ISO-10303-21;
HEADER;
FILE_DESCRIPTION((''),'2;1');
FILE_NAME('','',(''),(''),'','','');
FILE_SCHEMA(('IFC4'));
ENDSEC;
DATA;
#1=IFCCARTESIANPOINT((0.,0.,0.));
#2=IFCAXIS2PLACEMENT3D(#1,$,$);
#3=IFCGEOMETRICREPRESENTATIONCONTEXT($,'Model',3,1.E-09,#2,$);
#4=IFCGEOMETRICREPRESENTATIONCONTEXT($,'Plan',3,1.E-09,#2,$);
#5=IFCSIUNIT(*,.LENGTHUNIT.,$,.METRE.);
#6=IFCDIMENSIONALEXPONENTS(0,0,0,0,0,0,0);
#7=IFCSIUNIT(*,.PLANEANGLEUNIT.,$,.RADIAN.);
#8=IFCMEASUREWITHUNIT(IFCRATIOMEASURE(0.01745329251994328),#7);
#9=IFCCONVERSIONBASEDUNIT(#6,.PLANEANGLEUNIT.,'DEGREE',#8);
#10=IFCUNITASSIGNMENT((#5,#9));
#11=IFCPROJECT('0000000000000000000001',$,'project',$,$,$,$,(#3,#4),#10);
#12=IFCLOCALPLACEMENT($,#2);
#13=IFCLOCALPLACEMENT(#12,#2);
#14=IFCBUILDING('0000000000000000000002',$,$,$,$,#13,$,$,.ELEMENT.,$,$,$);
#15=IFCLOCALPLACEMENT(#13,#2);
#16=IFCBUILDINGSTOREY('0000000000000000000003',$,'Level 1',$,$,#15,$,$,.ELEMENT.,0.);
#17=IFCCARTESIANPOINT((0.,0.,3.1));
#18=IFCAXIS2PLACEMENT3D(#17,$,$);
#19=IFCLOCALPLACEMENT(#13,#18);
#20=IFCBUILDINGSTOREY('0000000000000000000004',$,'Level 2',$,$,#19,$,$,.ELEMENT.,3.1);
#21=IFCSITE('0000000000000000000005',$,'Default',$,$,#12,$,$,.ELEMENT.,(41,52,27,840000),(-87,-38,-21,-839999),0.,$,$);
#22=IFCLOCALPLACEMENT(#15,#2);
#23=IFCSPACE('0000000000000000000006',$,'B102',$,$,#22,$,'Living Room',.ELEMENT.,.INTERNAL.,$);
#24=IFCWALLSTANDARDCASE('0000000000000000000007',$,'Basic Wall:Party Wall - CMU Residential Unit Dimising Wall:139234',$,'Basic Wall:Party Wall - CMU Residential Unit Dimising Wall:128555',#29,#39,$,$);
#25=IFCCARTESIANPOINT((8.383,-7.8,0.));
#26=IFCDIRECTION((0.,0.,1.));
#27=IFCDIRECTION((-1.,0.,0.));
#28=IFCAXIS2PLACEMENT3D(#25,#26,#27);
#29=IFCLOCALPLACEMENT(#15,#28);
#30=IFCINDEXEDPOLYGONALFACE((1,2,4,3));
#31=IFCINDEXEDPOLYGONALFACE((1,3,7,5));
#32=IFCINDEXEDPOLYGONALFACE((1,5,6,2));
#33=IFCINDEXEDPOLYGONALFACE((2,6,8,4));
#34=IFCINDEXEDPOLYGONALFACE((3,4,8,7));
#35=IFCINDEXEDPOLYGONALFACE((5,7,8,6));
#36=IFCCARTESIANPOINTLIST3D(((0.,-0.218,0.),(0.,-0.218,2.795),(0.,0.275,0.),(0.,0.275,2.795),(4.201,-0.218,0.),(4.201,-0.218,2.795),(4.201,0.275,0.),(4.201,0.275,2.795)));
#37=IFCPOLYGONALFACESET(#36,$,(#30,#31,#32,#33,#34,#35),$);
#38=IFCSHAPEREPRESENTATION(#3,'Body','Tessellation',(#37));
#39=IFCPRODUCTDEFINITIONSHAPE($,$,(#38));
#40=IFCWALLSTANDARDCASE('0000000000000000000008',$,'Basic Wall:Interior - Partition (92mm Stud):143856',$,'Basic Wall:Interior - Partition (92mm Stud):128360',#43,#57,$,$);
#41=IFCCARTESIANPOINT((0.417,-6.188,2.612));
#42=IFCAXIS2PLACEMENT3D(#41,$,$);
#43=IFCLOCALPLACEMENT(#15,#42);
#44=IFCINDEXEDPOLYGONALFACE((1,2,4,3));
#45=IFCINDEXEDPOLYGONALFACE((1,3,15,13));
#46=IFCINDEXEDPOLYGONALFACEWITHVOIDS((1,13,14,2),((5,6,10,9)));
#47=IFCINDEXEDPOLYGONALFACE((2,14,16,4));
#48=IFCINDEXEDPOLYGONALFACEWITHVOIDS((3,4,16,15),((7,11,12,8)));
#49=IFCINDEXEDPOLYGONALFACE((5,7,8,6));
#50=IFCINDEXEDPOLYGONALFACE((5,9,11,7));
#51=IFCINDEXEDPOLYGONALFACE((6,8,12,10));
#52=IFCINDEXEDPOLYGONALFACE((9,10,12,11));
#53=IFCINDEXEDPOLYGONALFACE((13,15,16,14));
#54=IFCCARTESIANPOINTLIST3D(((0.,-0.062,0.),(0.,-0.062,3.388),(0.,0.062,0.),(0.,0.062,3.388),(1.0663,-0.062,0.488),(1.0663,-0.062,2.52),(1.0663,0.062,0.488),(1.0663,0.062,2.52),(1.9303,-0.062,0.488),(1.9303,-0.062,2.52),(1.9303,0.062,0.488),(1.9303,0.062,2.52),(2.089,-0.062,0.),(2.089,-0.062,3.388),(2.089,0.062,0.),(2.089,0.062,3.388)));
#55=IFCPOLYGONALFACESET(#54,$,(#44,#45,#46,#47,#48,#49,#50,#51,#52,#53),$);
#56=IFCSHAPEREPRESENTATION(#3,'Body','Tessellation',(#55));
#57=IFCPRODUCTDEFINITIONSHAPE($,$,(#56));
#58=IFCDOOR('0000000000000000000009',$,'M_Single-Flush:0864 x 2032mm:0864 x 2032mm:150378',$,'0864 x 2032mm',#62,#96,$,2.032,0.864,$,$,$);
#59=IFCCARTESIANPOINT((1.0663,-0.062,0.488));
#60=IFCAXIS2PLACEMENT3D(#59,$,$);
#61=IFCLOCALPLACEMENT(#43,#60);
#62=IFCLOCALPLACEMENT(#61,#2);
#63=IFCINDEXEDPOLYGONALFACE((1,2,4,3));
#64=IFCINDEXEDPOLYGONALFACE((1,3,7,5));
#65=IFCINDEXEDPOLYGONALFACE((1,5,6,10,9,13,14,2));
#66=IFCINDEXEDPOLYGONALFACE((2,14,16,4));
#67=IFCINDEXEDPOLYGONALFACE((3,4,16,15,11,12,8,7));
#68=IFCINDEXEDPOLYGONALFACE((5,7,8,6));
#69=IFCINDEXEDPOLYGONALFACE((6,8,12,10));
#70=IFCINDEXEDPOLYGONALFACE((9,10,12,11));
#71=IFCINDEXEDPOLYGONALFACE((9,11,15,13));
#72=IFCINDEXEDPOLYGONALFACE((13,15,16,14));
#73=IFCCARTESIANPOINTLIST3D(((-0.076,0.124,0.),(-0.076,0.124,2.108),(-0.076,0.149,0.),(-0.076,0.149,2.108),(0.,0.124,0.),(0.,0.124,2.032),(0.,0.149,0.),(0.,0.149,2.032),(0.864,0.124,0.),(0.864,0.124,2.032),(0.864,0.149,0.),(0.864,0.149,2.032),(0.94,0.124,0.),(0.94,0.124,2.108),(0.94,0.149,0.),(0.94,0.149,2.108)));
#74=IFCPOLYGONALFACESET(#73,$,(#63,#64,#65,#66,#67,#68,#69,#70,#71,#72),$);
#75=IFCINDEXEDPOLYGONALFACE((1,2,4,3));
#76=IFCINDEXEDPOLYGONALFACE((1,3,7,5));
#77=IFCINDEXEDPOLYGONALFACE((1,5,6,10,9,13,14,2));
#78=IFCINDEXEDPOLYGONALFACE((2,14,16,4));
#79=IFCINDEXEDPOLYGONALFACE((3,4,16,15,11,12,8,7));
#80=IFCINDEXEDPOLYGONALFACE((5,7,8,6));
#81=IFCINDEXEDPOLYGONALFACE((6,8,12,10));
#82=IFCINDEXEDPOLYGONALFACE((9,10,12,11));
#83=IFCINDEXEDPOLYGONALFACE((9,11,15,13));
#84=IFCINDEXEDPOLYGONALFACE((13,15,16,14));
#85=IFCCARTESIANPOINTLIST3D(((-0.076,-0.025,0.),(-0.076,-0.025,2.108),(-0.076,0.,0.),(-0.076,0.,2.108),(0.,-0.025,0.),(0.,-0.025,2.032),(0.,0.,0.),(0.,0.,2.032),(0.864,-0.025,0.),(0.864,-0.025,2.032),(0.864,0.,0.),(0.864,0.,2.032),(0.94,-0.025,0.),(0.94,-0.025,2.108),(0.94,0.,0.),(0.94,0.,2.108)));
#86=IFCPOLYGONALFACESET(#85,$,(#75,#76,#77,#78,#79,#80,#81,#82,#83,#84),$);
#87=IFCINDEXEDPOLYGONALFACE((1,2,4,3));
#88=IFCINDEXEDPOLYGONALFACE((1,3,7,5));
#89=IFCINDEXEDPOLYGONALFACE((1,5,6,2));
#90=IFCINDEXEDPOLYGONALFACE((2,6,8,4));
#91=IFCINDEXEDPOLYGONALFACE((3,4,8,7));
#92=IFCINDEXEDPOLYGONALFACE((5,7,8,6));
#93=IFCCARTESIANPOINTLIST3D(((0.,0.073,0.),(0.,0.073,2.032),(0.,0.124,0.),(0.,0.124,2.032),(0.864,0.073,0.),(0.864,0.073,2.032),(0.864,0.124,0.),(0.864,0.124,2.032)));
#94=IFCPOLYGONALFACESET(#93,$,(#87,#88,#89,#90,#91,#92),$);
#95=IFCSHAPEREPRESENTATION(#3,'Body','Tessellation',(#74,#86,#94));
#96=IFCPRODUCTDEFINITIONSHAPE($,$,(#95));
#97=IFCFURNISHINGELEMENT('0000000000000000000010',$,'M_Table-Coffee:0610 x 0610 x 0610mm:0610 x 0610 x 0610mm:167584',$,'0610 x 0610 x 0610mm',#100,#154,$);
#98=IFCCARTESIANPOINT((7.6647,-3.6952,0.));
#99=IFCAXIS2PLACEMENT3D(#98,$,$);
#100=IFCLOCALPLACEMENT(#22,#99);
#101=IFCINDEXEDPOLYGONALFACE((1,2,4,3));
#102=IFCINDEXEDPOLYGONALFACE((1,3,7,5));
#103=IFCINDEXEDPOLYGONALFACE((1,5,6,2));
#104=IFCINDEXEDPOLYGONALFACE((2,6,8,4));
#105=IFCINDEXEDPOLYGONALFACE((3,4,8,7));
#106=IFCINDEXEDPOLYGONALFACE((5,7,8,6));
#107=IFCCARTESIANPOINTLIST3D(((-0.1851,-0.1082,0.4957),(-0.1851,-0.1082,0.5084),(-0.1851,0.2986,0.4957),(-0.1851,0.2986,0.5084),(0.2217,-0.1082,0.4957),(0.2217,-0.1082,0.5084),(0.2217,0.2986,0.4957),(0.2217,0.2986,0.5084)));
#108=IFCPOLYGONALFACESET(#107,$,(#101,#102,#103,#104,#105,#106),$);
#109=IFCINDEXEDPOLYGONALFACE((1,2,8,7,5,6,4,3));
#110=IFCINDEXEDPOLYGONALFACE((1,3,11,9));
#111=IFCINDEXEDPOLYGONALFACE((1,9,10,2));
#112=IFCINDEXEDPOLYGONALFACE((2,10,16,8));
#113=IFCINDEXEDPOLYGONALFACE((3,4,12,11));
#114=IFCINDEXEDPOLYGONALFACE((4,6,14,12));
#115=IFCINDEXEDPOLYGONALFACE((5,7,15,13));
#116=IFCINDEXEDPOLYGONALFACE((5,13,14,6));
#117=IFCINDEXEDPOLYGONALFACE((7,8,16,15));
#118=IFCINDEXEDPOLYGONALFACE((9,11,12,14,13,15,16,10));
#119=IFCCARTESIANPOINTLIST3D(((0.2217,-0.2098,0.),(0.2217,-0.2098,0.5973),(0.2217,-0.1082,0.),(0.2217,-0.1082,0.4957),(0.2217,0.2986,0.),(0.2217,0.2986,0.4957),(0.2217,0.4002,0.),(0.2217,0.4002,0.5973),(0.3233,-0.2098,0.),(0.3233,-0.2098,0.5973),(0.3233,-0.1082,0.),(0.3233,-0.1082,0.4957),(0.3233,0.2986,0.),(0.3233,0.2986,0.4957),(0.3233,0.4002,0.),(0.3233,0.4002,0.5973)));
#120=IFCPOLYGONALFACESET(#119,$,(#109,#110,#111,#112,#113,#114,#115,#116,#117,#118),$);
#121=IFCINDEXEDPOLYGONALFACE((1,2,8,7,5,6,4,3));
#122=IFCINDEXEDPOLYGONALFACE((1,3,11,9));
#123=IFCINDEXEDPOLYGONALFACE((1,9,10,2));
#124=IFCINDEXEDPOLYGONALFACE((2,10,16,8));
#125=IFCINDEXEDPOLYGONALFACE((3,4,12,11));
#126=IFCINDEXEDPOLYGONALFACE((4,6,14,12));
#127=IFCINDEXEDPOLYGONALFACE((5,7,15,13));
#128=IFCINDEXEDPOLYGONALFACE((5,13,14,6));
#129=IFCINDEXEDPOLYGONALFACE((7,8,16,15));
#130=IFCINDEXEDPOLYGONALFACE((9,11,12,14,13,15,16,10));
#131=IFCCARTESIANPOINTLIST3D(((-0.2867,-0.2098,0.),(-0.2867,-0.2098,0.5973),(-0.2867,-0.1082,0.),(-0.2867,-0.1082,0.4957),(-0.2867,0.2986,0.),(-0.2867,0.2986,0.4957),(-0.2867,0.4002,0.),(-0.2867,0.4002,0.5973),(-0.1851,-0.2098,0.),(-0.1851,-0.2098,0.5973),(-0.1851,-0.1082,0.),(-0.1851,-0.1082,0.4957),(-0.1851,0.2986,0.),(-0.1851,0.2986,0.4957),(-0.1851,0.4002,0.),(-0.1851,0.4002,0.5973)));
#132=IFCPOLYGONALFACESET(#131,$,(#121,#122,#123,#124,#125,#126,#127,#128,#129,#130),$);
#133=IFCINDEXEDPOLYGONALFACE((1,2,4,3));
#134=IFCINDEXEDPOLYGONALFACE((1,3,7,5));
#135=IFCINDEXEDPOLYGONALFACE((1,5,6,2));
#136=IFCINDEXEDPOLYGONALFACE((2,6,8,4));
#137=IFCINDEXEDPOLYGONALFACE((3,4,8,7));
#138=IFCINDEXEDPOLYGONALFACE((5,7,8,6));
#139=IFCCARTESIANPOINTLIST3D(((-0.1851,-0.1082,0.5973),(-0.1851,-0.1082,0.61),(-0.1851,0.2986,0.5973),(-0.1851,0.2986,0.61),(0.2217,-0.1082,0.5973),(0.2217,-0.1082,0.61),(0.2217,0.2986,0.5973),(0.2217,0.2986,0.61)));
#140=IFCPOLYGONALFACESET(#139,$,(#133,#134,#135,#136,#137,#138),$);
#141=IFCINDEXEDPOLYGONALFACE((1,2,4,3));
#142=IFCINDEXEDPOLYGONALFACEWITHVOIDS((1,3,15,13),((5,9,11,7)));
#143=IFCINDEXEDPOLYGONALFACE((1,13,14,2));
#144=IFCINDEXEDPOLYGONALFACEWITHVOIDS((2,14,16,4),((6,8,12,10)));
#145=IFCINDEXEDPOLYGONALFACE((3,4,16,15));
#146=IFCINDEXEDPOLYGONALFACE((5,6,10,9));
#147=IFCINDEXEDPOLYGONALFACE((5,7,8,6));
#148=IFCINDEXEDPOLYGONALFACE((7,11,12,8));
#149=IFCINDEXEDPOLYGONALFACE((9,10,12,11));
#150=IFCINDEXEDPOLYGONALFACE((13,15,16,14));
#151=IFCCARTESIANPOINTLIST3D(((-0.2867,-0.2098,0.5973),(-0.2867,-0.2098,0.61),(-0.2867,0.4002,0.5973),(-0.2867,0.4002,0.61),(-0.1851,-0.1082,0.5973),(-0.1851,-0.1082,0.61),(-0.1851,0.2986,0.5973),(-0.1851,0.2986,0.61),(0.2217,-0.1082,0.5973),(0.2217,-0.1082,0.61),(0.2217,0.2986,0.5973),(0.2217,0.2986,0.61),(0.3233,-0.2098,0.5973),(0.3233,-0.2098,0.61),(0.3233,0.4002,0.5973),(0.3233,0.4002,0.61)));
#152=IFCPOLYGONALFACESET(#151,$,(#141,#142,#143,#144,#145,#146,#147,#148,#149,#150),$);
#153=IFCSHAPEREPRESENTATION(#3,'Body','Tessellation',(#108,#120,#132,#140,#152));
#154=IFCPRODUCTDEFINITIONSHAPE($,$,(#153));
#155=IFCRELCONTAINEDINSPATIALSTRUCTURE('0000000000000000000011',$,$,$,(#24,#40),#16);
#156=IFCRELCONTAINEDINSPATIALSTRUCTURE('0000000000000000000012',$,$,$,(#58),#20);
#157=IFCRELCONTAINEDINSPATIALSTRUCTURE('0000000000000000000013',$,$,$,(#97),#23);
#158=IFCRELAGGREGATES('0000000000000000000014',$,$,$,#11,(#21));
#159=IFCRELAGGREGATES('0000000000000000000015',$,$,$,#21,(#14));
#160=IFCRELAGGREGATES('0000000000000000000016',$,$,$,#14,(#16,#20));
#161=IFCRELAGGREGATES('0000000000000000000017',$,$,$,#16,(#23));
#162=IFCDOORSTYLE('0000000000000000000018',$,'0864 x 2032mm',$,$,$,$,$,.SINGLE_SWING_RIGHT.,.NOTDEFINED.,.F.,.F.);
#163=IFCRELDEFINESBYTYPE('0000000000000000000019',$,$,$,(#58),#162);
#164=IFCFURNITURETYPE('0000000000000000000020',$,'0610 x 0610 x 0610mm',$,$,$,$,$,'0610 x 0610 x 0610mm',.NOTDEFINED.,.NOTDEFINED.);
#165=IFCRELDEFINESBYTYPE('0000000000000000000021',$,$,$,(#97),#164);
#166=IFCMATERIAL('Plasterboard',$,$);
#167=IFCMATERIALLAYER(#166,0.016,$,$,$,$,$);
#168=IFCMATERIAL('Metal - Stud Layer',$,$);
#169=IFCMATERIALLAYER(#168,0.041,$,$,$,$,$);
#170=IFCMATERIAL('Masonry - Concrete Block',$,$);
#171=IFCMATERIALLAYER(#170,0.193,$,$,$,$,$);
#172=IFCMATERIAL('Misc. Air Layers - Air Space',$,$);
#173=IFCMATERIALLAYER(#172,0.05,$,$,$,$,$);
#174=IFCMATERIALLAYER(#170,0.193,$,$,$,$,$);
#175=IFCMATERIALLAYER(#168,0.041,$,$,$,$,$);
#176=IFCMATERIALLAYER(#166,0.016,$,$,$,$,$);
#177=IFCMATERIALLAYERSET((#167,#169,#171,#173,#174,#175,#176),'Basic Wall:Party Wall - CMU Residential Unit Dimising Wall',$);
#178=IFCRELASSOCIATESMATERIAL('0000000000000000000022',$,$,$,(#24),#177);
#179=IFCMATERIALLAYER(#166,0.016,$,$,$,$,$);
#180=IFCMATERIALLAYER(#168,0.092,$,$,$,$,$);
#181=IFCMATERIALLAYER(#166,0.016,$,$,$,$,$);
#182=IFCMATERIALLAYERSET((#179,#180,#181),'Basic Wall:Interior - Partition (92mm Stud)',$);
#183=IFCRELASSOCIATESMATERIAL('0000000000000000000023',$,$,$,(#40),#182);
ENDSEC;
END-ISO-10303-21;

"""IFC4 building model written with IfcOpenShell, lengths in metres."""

from ifc_helpers import new_model, entity, si_unit, converted_unit, frame, frame_2d, origin, origin_2d_with_axis, place, context, project, spatial, polyline, rectangle, outline, extrude, clip, bounded_halfspace, source, transform, mapped, material, layer, layer_set, layer_usage, type_object, type_shapes, element, fill, save


model = new_model("IFC4")

# Units and contexts
model_context = context("Model", 3, precision=1e-09, world=origin())
plan_context = context("Plan", 3, precision=1e-09, world=origin())
ifc_project = project(units=[si_unit("LENGTHUNIT", "METRE"), converted_unit("PLANEANGLEUNIT", "DEGREE", entity("IfcRatioMeasure", 0.01745329251994328), si_unit("PLANEANGLEUNIT", "RADIAN"), dimensions=[0, 0, 0, 0, 0, 0, 0])], contexts=[model_context, plan_context])

# Site, building, storey
site_placement = place(None, origin())
site = spatial("IfcSite", under=ifc_project, at=site_placement, Name="Default", CompositionType="ELEMENT", RefLatitude=(41, 52, 27, 840000), RefLongitude=(-87, -38, -21, -839999), RefElevation=0.0)
building_placement = place(site_placement, origin())
building = spatial("IfcBuilding", under=site, at=building_placement, CompositionType="ELEMENT")
storey_1_placement = place(building_placement, origin())
storey_1 = spatial("IfcBuildingStorey", under=building, at=storey_1_placement, Name="Level 1", CompositionType="ELEMENT", Elevation=0.0)

# Shared definitions
ifc_material_1 = material(Name="Misc. Air Layers - Air Space")
ifc_material_2 = material(Name="Masonry - Concrete Block")
ifc_material_3 = material(Name="Metal - Stud Layer")
ifc_material_4 = material(Name="Plasterboard")

# Shared definitions
ifc_layer_1 = layer(ifc_material_4, 0.016)
ifc_layer_2 = layer(ifc_material_3, 0.092)
ifc_layer_3 = layer(ifc_material_4, 0.016)
ifc_layer_set_1 = layer_set([ifc_layer_1, ifc_layer_2, ifc_layer_3], Name="Basic Wall:Interior - Partition (92mm Stud)")

# Wall
ifc_layer_4 = layer(ifc_material_4, 0.016)
ifc_layer_5 = layer(ifc_material_3, 0.041)
ifc_layer_6 = layer(ifc_material_2, 0.193)
ifc_layer_7 = layer(ifc_material_1, 0.05)
ifc_layer_8 = layer(ifc_material_2, 0.193)
ifc_layer_9 = layer(ifc_material_3, 0.041)
ifc_layer_10 = layer(ifc_material_4, 0.016)
ifc_layer_set_2 = layer_set([ifc_layer_4, ifc_layer_5, ifc_layer_6, ifc_layer_7, ifc_layer_8, ifc_layer_9, ifc_layer_10], Name="Basic Wall:Party Wall - CMU Residential Unit Dimising Wall")
ifc_layer_usage_1 = layer_usage(ifc_layer_set_2, "AXIS2", "NEGATIVE", 0.275)
wall_1_placement = place(storey_1_placement, frame((8.383, -7.8, 0.0), z_axis=(0.0, 0.0, 1.0), x_axis=(-1.0, 0.0, 0.0)))
element("IfcWallStandardCase", 1, at=wall_1_placement, inside=storey_1, material=ifc_layer_usage_1, Name="Basic Wall:Party Wall - CMU Residential Unit Dimising Wall:139234", ObjectType="Basic Wall:Party Wall - CMU Residential Unit Dimising Wall:128555", context=model_context, shape_type="Clipping", body=[
    clip(clip(extrude(rectangle(XDim=4.201, YDim=0.55, at=frame_2d((2.1005, 0.0), x_axis=(-1.0, 0.0))), origin(), (0.0, 0.0, 1.0), 2.795), bounded_halfspace(frame((0.0, -0.218, 2.795), z_axis=(0.0, 1.0, 0.0), x_axis=(-1.0, 0.0, 0.0)), True, frame((0.0, -0.218, 2.795), z_axis=(0.0, 1.0, 0.0), x_axis=(-1.0, 0.0, 0.0)), polyline([(0.0, 0.0), (-3.708, 0.0), (-4.201, 0.0), (-4.201, -2.795), (0.0, -2.795), (0.0, 0.0)]))), bounded_halfspace(frame((4.201, 0.275, 0.0), z_axis=(-1.0, 0.0, 0.0), x_axis=(0.0, -1.0, 0.0)), True, frame((4.201, 0.275, 0.0), z_axis=(-1.0, 0.0, 0.0), x_axis=(0.0, -1.0, 0.0)), polyline([(0.0, 0.0), (0.493, 0.0), (0.493, 2.795), (0.0, 2.795), (0.0, 0.0)]))),
])

# Wall, opening
ifc_layer_usage_2 = layer_usage(ifc_layer_set_1, "AXIS2", "NEGATIVE", 0.062)
wall_2_placement = place(storey_1_placement, frame((0.417, -6.188, 2.612)))
wall_2 = element("IfcWallStandardCase", 2, at=wall_2_placement, inside=storey_1, material=ifc_layer_usage_2, Name="Basic Wall:Interior - Partition (92mm Stud):143856", ObjectType="Basic Wall:Interior - Partition (92mm Stud):128360", context=model_context, shape_type="SweptSolid", body=[
    extrude(rectangle(XDim=2.089, YDim=0.124, at=frame_2d((1.0445, 0.0), x_axis=(-1.0, 0.0))), origin(), (0.0, 0.0, 1.0), 3.388),
])
opening_1_placement = place(wall_2_placement, frame((1.0663, -0.062, 0.488)))
opening_1 = element("IfcOpeningElement", 3, at=opening_1_placement, cuts=wall_2, ObjectType="Opening", context=model_context, shape_type="SweptSolid", body=[
    extrude(rectangle(XDim=0.864, YDim=2.032, at=frame_2d((1.016, 0.432), x_axis=(0.0, 1.0))), frame((0.0, 0.0, 0.0), z_axis=(0.0, 1.0, 0.0), x_axis=(0.0, 0.0, 1.0)), (0.0, 0.0, 1.0), 0.124),
])

# Shared definitions
storey_2_placement = place(building_placement, frame((0.0, 0.0, 3.1)))
storey_2 = spatial("IfcBuildingStorey", under=building, at=storey_2_placement, Name="Level 2", CompositionType="ELEMENT", Elevation=3.1)

# Door
door_style_1 = type_object("IfcDoorStyle", Name="0864 x 2032mm", ConstructionType="NOTDEFINED", OperationType="SINGLE_SWING_RIGHT", ParameterTakesPrecedence=False, Sizeable=False)
shared_shape_1 = source(origin(), model_context, "Body", "SweptSolid", [
    extrude(outline(polyline([(-0.508, -1.073), (0.508, -1.073), (0.508, 1.035), (0.432, 1.035), (0.432, -0.997), (-0.432, -0.997), (-0.432, 1.035), (-0.508, 1.035), (-0.508, -1.073)])), frame((0.432, 0.124, 1.035), z_axis=(0.0, 1.0, 0.0), x_axis=(1.0, 0.0, 0.0)), (0.0, 0.0, 1.0), 0.025),
    extrude(outline(polyline([(-1.073, -0.508), (1.035, -0.508), (1.035, -0.432), (-0.997, -0.432), (-0.997, 0.432), (1.035, 0.432), (1.035, 0.508), (-1.073, 0.508), (-1.073, -0.508)])), frame((0.432, -0.025, 1.035), z_axis=(0.0, 1.0, 0.0), x_axis=(0.0, 0.0, -1.0)), (0.0, 0.0, 1.0), 0.025),
    extrude(rectangle(XDim=0.051, YDim=0.864, at=origin_2d_with_axis()), frame((0.432, 0.0985, 0.0), z_axis=(0.0, 0.0, 1.0), x_axis=(0.0, 1.0, 0.0)), (0.0, 0.0, 1.0), 2.032),
])
type_shapes(door_style_1, [shared_shape_1])
door_1_placement = place(opening_1_placement, origin())
door_1 = element("IfcDoor", 4, at=door_1_placement, inside=storey_2, type_object=door_style_1, Name="M_Single-Flush:0864 x 2032mm:0864 x 2032mm:150378", ObjectType="0864 x 2032mm", OverallHeight=2.032, OverallWidth=0.864, context=model_context, shape_type="MappedRepresentation", body=[
    mapped(shared_shape_1, transform((0.0, 0.0, 0.0), scale=1.0)),
])
fill(opening_1, door_1)

# Shared definitions
space_1_placement = place(storey_1_placement, origin())
space_1 = spatial("IfcSpace", under=storey_1, at=space_1_placement, Name="B102", LongName="Living Room", CompositionType="ELEMENT", PredefinedType="INTERNAL")

# Furnishing element
furniture_type_1 = type_object("IfcFurnitureType", Name="0610 x 0610 x 0610mm", ElementType="0610 x 0610 x 0610mm", AssemblyPlace="NOTDEFINED")
shared_shape_2 = source(origin(), model_context, "Body", "SweptSolid", [
    extrude(rectangle(XDim=0.4068, YDim=0.4068, at=origin_2d_with_axis()), frame((0.0183, 0.0952, 0.4957), z_axis=(0.0, 0.0, 1.0), x_axis=(-1.0, 0.0, 0.0)), (0.0, 0.0, 1.0), 0.0127),
    extrude(outline(polyline([(-0.2732, -0.305), (0.324, -0.305), (0.324, 0.305), (-0.2732, 0.305), (-0.2732, 0.2034), (0.2225, 0.2034), (0.2225, -0.2034), (-0.2732, -0.2034), (-0.2732, -0.305)])), frame((0.2217, 0.0952, 0.2732), z_axis=(1.0, 0.0, 0.0), x_axis=(0.0, 0.0, 1.0)), (0.0, 0.0, 1.0), 0.1016),
    extrude(outline(polyline([(-0.305, -0.3241), (0.305, -0.3241), (0.305, 0.2733), (0.2034, 0.2733), (0.2034, -0.2224), (-0.2034, -0.2224), (-0.2034, 0.2733), (-0.305, 0.2733), (-0.305, -0.3241)])), frame((-0.2867, 0.0952, 0.2733), z_axis=(1.0, 0.0, 0.0), x_axis=(0.0, -1.0, 0.0)), (0.0, 0.0, 1.0), 0.1016),
    extrude(rectangle(XDim=0.4068, YDim=0.4068, at=origin_2d_with_axis()), frame((0.0183, 0.0952, 0.5973), z_axis=(0.0, 0.0, 1.0), x_axis=(-1.0, 0.0, 0.0)), (0.0, 0.0, 1.0), 0.0127),
    extrude(outline(polyline([(-0.305, -0.305), (0.305, -0.305), (0.305, 0.305), (-0.305, 0.305), (-0.305, -0.305)]), holes=[polyline([(-0.2034, -0.2034), (-0.2034, 0.2034), (0.2034, 0.2034), (0.2034, -0.2034), (-0.2034, -0.2034)])]), frame((0.0183, 0.0952, 0.5973), z_axis=(0.0, 0.0, 1.0), x_axis=(-1.0, 0.0, 0.0)), (0.0, 0.0, 1.0), 0.0127),
])
type_shapes(furniture_type_1, [shared_shape_2])
for number, where, name in (
    (5, (7.6647, -3.6952, 0.0), "M_Table-Coffee:0610 x 0610 x 0610mm:0610 x 0610 x 0610mm:167584"),
):
    element("IfcFurnishingElement", number, at=place(space_1_placement, frame(where)), inside=space_1, type_object=furniture_type_1, Name=name, ObjectType="0610 x 0610 x 0610mm", context=model_context, shape_type="MappedRepresentation", body=[
        mapped(shared_shape_2, transform((0.0, 0.0, 0.0), scale=1.0)),
    ])

save(model, "model.ifc")
